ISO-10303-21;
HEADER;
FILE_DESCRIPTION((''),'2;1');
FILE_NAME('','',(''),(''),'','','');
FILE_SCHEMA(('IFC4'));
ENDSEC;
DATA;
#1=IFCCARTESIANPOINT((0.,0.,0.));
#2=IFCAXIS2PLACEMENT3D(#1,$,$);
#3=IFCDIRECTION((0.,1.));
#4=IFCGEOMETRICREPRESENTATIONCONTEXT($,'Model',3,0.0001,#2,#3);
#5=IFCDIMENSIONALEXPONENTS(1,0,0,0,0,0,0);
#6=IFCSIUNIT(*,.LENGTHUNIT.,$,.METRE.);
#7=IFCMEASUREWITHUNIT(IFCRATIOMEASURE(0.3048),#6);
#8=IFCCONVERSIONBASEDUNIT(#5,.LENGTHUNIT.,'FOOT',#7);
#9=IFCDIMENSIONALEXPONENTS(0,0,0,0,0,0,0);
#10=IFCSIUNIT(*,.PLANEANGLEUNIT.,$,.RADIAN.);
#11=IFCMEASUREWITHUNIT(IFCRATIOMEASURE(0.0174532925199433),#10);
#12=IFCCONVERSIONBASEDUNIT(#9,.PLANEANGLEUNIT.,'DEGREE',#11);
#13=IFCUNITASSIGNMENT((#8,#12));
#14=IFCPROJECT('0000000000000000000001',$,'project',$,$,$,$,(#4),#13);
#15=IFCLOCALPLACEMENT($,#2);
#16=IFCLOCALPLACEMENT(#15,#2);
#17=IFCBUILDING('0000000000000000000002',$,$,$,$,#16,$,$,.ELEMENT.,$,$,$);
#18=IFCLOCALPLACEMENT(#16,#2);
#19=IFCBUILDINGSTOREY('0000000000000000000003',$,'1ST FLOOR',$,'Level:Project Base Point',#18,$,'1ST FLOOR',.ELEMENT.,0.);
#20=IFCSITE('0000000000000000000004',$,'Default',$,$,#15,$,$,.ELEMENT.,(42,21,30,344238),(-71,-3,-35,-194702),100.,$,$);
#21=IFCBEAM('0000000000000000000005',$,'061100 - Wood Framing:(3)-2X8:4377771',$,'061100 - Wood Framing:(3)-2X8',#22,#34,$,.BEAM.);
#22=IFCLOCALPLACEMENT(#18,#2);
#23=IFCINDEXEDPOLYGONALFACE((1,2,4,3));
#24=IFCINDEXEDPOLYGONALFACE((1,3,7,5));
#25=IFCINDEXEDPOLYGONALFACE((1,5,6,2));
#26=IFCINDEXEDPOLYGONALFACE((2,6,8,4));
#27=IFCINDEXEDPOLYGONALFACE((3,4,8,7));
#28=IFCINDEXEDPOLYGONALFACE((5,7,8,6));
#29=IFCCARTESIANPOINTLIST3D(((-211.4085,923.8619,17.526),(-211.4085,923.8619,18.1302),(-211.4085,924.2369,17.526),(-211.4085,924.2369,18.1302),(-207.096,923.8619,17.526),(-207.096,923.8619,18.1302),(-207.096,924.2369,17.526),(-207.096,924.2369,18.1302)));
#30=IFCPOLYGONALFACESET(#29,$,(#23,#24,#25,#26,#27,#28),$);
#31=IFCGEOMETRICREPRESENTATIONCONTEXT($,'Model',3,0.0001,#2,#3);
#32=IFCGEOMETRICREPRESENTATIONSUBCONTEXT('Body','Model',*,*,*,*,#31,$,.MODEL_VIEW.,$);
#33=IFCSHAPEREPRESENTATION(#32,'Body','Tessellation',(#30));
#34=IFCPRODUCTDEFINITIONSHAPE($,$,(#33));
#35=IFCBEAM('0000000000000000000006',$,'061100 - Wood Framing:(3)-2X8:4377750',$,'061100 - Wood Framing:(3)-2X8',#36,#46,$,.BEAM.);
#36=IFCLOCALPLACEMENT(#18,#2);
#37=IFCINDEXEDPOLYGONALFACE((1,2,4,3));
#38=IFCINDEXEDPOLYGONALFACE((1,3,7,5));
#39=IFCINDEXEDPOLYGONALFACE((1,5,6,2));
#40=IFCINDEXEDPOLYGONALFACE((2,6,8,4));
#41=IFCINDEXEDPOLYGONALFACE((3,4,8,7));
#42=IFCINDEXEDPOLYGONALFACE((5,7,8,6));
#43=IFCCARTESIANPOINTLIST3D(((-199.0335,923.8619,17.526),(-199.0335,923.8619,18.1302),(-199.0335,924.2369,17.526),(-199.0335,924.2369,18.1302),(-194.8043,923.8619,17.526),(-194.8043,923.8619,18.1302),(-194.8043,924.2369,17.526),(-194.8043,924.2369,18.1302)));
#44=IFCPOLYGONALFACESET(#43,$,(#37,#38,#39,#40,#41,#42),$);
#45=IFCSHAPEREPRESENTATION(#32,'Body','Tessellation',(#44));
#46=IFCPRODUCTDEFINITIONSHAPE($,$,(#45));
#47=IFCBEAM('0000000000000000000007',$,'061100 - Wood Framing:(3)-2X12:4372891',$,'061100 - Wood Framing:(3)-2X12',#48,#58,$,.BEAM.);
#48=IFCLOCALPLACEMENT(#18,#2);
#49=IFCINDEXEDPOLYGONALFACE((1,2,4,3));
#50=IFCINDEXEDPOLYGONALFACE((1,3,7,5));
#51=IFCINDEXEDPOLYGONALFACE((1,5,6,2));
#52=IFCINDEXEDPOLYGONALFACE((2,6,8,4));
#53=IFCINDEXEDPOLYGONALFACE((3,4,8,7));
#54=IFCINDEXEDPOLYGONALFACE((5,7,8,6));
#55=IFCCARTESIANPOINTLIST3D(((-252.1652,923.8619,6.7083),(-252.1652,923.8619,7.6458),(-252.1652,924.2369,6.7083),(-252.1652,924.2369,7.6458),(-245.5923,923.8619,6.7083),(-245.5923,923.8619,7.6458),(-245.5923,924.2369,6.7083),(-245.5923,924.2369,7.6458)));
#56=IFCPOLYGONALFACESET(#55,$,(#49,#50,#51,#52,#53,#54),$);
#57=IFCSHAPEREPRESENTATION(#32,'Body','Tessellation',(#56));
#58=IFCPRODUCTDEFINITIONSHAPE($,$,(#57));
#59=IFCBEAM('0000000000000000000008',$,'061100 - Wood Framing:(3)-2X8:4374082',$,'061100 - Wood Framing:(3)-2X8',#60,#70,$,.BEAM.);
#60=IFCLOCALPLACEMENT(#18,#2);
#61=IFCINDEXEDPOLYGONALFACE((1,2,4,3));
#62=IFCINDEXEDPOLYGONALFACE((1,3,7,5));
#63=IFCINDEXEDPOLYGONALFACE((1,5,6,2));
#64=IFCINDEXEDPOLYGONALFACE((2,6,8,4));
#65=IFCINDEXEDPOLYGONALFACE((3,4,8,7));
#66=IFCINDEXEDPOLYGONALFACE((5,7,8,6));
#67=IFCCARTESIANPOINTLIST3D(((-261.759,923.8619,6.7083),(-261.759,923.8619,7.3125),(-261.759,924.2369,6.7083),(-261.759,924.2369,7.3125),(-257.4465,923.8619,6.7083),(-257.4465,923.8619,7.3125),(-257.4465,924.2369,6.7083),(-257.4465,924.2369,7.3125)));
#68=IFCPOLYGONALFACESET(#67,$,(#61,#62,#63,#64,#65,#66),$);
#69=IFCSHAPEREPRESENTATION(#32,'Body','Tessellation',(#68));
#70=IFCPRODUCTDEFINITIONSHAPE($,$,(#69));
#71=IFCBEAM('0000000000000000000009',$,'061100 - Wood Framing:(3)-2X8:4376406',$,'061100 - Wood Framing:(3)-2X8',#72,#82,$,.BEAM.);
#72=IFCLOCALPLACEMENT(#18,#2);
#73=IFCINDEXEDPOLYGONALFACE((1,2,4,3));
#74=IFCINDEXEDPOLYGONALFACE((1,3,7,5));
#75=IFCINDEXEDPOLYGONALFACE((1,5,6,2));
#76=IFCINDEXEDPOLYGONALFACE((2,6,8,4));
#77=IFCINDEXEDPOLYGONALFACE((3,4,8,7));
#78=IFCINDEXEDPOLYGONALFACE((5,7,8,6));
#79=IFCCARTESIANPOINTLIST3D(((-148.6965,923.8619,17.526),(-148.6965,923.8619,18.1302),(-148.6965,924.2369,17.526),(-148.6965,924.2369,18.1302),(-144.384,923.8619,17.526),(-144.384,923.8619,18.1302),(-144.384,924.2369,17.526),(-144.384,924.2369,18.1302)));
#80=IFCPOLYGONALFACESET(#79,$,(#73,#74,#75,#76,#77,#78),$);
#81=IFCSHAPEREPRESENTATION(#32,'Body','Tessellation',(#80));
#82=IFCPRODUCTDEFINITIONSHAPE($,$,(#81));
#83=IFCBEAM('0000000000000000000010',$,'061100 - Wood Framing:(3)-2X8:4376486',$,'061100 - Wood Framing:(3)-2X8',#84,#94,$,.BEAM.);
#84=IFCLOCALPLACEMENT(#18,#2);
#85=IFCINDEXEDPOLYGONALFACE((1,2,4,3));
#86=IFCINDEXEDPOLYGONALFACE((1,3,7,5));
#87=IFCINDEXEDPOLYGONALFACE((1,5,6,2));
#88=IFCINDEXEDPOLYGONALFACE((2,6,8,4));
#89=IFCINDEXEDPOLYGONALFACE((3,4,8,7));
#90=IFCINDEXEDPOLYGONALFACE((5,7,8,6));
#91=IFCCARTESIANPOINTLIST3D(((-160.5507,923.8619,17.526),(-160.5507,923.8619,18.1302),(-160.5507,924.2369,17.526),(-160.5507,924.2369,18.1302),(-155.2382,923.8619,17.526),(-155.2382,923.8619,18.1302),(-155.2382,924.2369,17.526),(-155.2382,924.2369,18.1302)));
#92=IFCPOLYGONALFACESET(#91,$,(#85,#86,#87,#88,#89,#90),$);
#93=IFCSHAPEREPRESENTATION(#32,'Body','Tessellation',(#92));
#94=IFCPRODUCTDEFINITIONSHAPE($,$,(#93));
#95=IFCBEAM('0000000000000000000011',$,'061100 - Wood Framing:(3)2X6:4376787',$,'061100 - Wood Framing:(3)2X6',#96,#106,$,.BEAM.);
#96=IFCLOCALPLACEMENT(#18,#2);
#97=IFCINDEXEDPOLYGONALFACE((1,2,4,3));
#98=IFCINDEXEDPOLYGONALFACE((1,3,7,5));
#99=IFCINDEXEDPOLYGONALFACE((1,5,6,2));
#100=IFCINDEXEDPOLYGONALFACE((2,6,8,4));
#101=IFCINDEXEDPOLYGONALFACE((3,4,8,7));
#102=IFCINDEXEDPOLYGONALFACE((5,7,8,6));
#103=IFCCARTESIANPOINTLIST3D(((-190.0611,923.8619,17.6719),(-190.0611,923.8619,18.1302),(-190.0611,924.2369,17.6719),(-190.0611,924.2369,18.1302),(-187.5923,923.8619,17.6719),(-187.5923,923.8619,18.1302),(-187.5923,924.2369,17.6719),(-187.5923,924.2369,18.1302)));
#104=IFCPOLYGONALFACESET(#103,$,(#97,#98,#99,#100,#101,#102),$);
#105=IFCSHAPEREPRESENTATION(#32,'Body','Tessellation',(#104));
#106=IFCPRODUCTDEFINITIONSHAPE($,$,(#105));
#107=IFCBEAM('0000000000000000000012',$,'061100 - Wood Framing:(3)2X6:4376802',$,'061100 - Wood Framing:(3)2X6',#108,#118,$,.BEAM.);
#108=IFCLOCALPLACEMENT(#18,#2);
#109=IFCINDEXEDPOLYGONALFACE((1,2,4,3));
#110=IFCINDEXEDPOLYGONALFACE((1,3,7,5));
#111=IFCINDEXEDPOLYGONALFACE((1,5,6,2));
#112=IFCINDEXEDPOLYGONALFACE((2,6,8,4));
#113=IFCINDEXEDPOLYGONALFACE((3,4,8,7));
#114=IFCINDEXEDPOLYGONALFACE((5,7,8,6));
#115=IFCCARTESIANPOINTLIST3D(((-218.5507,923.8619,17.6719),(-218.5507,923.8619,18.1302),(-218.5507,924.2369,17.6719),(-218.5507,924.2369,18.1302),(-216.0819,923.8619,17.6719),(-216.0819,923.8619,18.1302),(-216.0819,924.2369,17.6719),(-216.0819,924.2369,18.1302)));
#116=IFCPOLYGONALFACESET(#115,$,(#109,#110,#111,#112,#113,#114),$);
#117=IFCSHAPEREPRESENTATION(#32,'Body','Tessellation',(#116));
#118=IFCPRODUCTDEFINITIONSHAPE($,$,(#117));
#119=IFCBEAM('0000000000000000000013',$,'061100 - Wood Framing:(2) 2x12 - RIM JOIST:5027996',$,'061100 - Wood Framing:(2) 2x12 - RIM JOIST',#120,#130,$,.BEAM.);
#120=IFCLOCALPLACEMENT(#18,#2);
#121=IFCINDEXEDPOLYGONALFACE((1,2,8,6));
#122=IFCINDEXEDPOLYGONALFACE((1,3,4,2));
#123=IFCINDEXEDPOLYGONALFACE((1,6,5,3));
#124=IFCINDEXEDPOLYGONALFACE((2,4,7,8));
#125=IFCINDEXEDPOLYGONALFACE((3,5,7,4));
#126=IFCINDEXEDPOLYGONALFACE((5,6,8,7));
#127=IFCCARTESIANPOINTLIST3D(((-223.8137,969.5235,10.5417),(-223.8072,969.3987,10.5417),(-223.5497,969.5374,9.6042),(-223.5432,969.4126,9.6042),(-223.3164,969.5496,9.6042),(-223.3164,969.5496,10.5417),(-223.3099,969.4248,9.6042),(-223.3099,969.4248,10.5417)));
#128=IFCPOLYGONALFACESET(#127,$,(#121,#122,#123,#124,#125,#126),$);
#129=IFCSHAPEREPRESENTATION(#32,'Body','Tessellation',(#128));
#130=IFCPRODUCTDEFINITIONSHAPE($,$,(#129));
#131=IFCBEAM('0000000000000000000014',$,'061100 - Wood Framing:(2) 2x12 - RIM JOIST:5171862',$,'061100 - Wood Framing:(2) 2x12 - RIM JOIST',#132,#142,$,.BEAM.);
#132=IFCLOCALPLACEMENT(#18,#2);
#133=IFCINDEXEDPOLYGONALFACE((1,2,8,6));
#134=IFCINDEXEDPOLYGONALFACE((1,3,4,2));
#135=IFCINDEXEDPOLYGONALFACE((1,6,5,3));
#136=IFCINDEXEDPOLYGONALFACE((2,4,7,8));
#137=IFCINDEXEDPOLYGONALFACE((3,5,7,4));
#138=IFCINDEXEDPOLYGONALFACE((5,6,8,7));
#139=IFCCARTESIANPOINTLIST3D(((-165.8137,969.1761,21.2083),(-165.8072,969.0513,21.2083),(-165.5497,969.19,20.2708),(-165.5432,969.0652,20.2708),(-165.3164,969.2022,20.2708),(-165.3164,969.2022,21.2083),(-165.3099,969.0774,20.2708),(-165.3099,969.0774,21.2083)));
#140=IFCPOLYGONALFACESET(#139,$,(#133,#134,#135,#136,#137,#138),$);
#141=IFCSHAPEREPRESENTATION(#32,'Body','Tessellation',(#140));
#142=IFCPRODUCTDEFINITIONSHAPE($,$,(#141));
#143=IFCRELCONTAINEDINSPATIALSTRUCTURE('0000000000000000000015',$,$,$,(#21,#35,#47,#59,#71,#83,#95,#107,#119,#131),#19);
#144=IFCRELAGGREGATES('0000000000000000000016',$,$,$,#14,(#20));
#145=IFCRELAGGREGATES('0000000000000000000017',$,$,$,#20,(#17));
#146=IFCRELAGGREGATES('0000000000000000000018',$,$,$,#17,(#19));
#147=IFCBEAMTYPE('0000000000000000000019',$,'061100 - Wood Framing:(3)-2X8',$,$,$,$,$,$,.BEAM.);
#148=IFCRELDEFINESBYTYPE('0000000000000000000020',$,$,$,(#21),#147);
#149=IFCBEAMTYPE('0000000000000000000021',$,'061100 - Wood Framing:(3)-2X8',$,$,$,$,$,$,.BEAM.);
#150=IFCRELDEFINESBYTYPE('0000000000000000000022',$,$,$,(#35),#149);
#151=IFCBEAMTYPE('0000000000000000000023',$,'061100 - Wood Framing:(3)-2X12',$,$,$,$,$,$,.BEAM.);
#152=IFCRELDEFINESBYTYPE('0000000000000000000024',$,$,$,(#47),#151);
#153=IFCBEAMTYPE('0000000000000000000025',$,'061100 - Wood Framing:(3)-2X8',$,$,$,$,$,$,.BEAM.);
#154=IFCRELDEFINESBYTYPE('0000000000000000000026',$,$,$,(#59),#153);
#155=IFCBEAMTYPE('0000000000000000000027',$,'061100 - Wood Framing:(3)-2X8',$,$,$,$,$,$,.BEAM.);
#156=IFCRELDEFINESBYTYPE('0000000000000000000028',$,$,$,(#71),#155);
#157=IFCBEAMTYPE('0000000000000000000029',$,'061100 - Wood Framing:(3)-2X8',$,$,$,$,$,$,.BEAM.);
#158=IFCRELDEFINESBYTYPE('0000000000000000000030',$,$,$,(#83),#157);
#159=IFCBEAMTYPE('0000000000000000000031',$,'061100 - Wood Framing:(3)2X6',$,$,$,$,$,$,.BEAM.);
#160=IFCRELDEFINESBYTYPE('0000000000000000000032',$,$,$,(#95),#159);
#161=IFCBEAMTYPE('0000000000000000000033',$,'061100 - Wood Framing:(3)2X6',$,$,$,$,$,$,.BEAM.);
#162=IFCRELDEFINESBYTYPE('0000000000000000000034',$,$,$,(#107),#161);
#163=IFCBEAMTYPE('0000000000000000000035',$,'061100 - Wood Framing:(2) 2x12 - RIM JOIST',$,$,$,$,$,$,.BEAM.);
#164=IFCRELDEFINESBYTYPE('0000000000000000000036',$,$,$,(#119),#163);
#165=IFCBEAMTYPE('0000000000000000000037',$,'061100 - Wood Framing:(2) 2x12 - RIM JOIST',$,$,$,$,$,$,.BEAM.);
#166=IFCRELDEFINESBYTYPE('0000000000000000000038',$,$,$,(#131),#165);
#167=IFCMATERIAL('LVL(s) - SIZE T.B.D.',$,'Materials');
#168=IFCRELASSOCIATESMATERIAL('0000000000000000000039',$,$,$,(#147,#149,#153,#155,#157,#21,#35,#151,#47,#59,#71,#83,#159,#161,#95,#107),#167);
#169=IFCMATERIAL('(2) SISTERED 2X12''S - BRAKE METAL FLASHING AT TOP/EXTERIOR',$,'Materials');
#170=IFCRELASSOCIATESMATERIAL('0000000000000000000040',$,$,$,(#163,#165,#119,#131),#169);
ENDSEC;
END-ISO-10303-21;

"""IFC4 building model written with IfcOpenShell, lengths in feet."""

from ifc_helpers import new_model, entity, si_unit, converted_unit, direction, frame, frame_2d, origin, place, context, subcontext, project, spatial, rectangle, extrude, clip, halfspace, source, transform, mapped, material, material_profile, profile_set, profile_usage, type_object, type_shapes, element, save


model = new_model("IFC4")

# Units and contexts
model_context_1 = context("Model", 3, precision=0.0001, world=origin(), true_north=direction((0.0, 1.0)))
model_context_2 = context("Model", 3, precision=0.0001, world=origin(), true_north=direction((0.0, 1.0)))
body_context = subcontext(model_context_2, "Body", "Model", "MODEL_VIEW")
ifc_project = project(units=[converted_unit("LENGTHUNIT", "FOOT", entity("IfcRatioMeasure", 0.3048), si_unit("LENGTHUNIT", "METRE"), dimensions=[1, 0, 0, 0, 0, 0, 0]), converted_unit("PLANEANGLEUNIT", "DEGREE", entity("IfcRatioMeasure", 0.0174532925199433), si_unit("PLANEANGLEUNIT", "RADIAN"), dimensions=[0, 0, 0, 0, 0, 0, 0])], contexts=[model_context_1])

# Site, building, storey
site_placement = place(None, origin())
site = spatial("IfcSite", under=ifc_project, at=site_placement, Name="Default", CompositionType="ELEMENT", RefLatitude=(42, 21, 30, 344238), RefLongitude=(-71, -3, -35, -194702), RefElevation=100.0)
building_placement = place(site_placement, origin())
building = spatial("IfcBuilding", under=site, at=building_placement, CompositionType="ELEMENT")
storey_placement = place(building_placement, origin())
storey = spatial("IfcBuildingStorey", under=building, at=storey_placement, Name="1ST FLOOR", ObjectType="Level:Project Base Point", LongName="1ST FLOOR", CompositionType="ELEMENT", Elevation=0.0)

# Beams
ifc_material_1 = material(Name="LVL(s) - SIZE T.B.D.", Category="Materials")
ifc_material_profile_1 = material_profile(ifc_material_1, rectangle(XDim=0.6042, YDim=0.375, at=frame_2d((0.0, 0.0), x_axis=(1.0, 0.0))), Name="(3)-2X8")
ifc_profile_set_1 = profile_set([ifc_material_profile_1], Name="(3)-2X8")
ifc_profile_usage_1 = profile_usage(ifc_profile_set_1, cardinal=8)
beam_type_1 = type_object("IfcBeamType", Name="061100 - Wood Framing:(3)-2X8", PredefinedType="BEAM", material=ifc_profile_set_1)
shared_shape_1 = source(origin(), body_context, "Body", "SweptSolid", [
    extrude(rectangle(XDim=0.6042, YDim=0.375, at=frame_2d((0.0, 0.0), x_axis=(1.0, 0.0))), frame((-2.1777, 0.0, 0.0), z_axis=(1.0, 0.0, 0.0), x_axis=(0.0, 0.0, -1.0)), (0.0, 0.0, 1.0), 4.3125),
])
type_shapes(beam_type_1, [shared_shape_1])
beam_1_placement = place(storey_placement, frame((-209.2308, 924.0494, 17.8281)))
element("IfcBeam", 1, at=beam_1_placement, inside=storey, type_object=beam_type_1, material=ifc_profile_usage_1, Name="061100 - Wood Framing:(3)-2X8:4377771", ObjectType="061100 - Wood Framing:(3)-2X8", PredefinedType="BEAM", context=body_context, shape_type="MappedRepresentation", body=[
    mapped(shared_shape_1, transform((0.0, 0.0, 0.0), scale=1.0)),
])
ifc_profile_usage_2 = profile_usage(ifc_profile_set_1, cardinal=8)
beam_type_2 = type_object("IfcBeamType", Name="061100 - Wood Framing:(3)-2X8", PredefinedType="BEAM", material=ifc_profile_set_1)
shared_shape_2 = source(origin(), body_context, "Body", "SweptSolid", [
    extrude(rectangle(XDim=0.6042, YDim=0.375, at=frame_2d((0.0, 0.0), x_axis=(1.0, 0.0))), frame((-2.136, 0.0, 0.0), z_axis=(1.0, 0.0, 0.0), x_axis=(0.0, 0.0, -1.0)), (0.0, 0.0, 1.0), 4.2292),
])
type_shapes(beam_type_2, [shared_shape_2])
beam_2_placement = place(storey_placement, frame((-196.8975, 924.0494, 17.8281)))
element("IfcBeam", 2, at=beam_2_placement, inside=storey, type_object=beam_type_2, material=ifc_profile_usage_2, Name="061100 - Wood Framing:(3)-2X8:4377750", ObjectType="061100 - Wood Framing:(3)-2X8", PredefinedType="BEAM", context=body_context, shape_type="MappedRepresentation", body=[
    mapped(shared_shape_2, transform((0.0, 0.0, 0.0), scale=1.0)),
])
ifc_material_profile_2 = material_profile(ifc_material_1, rectangle(XDim=0.9375, YDim=0.375, at=frame_2d((0.0, 0.0), x_axis=(1.0, 0.0))), Name="(3)-2X12")
ifc_profile_set_2 = profile_set([ifc_material_profile_2], Name="(3)-2X12")
ifc_profile_usage_3 = profile_usage(ifc_profile_set_2, cardinal=8)
beam_type_3 = type_object("IfcBeamType", Name="061100 - Wood Framing:(3)-2X12", PredefinedType="BEAM", material=ifc_profile_set_2)
shared_shape_3 = source(origin(), body_context, "Body", "SweptSolid", [
    extrude(rectangle(XDim=0.9375, YDim=0.375, at=frame_2d((0.0, 0.0), x_axis=(1.0, 0.0))), frame((-3.2765, 0.0, 0.0), z_axis=(1.0, 0.0, 0.0), x_axis=(0.0, 0.0, -1.0)), (0.0, 0.0, 1.0), 6.5729),
])
type_shapes(beam_type_3, [shared_shape_3])
beam_3_placement = place(storey_placement, frame((-248.8888, 924.0494, 7.1771)))
element("IfcBeam", 3, at=beam_3_placement, inside=storey, type_object=beam_type_3, material=ifc_profile_usage_3, Name="061100 - Wood Framing:(3)-2X12:4372891", ObjectType="061100 - Wood Framing:(3)-2X12", PredefinedType="BEAM", context=body_context, shape_type="MappedRepresentation", body=[
    mapped(shared_shape_3, transform((0.0, 0.0, 0.0), scale=1.0)),
])
ifc_profile_usage_4 = profile_usage(ifc_profile_set_1, cardinal=8)
beam_type_4 = type_object("IfcBeamType", Name="061100 - Wood Framing:(3)-2X8", PredefinedType="BEAM", material=ifc_profile_set_1)
shared_shape_4 = source(origin(), body_context, "Body", "SweptSolid", [
    extrude(rectangle(XDim=0.6042, YDim=0.375, at=frame_2d((0.0, 0.0), x_axis=(1.0, 0.0))), frame((-2.1594, 0.0, 0.0), z_axis=(1.0, 0.0, 0.0), x_axis=(0.0, 0.0, -1.0)), (0.0, 0.0, 1.0), 4.3125),
])
type_shapes(beam_type_4, [shared_shape_4])
beam_4_placement = place(storey_placement, frame((-259.5996, 924.0494, 7.0104)))
element("IfcBeam", 4, at=beam_4_placement, inside=storey, type_object=beam_type_4, material=ifc_profile_usage_4, Name="061100 - Wood Framing:(3)-2X8:4374082", ObjectType="061100 - Wood Framing:(3)-2X8", PredefinedType="BEAM", context=body_context, shape_type="MappedRepresentation", body=[
    mapped(shared_shape_4, transform((0.0, 0.0, 0.0), scale=1.0)),
])
ifc_profile_usage_5 = profile_usage(ifc_profile_set_1, cardinal=8)
beam_type_5 = type_object("IfcBeamType", Name="061100 - Wood Framing:(3)-2X8", PredefinedType="BEAM", material=ifc_profile_set_1)
shared_shape_5 = source(origin(), body_context, "Body", "SweptSolid", [
    extrude(rectangle(XDim=0.6042, YDim=0.375, at=frame_2d((0.0, 0.0), x_axis=(1.0, 0.0))), frame((-2.1777, 0.0, 0.0), z_axis=(1.0, 0.0, 0.0), x_axis=(0.0, 0.0, -1.0)), (0.0, 0.0, 1.0), 4.3125),
])
type_shapes(beam_type_5, [shared_shape_5])
beam_5_placement = place(storey_placement, frame((-146.5188, 924.0494, 17.8281)))
element("IfcBeam", 5, at=beam_5_placement, inside=storey, type_object=beam_type_5, material=ifc_profile_usage_5, Name="061100 - Wood Framing:(3)-2X8:4376406", ObjectType="061100 - Wood Framing:(3)-2X8", PredefinedType="BEAM", context=body_context, shape_type="MappedRepresentation", body=[
    mapped(shared_shape_5, transform((0.0, 0.0, 0.0), scale=1.0)),
])
ifc_profile_usage_6 = profile_usage(ifc_profile_set_1, cardinal=8)
beam_type_6 = type_object("IfcBeamType", Name="061100 - Wood Framing:(3)-2X8", PredefinedType="BEAM", material=ifc_profile_set_1)
shared_shape_6 = source(origin(), body_context, "Body", "SweptSolid", [
    extrude(rectangle(XDim=0.6042, YDim=0.375, at=frame_2d((0.0, 0.0), x_axis=(1.0, 0.0))), frame((-2.6596, 0.0, 0.0), z_axis=(1.0, 0.0, 0.0), x_axis=(0.0, 0.0, -1.0)), (0.0, 0.0, 1.0), 5.3125),
])
type_shapes(beam_type_6, [shared_shape_6])
beam_6_placement = place(storey_placement, frame((-157.891, 924.0494, 17.8281)))
element("IfcBeam", 6, at=beam_6_placement, inside=storey, type_object=beam_type_6, material=ifc_profile_usage_6, Name="061100 - Wood Framing:(3)-2X8:4376486", ObjectType="061100 - Wood Framing:(3)-2X8", PredefinedType="BEAM", context=body_context, shape_type="MappedRepresentation", body=[
    mapped(shared_shape_6, transform((0.0, 0.0, 0.0), scale=1.0)),
])
ifc_material_profile_3 = material_profile(ifc_material_1, rectangle(XDim=0.4583, YDim=0.375, at=frame_2d((0.0, 0.0), x_axis=(1.0, 0.0))), Name="(3)2X6")
ifc_profile_set_3 = profile_set([ifc_material_profile_3], Name="(3)2X6")
ifc_profile_usage_7 = profile_usage(ifc_profile_set_3, cardinal=8)
beam_type_7 = type_object("IfcBeamType", Name="061100 - Wood Framing:(3)2X6", PredefinedType="BEAM", material=ifc_profile_set_3)
shared_shape_7 = source(origin(), body_context, "Body", "SweptSolid", [
    extrude(rectangle(XDim=0.4583, YDim=0.375, at=frame_2d((0.0, 0.0), x_axis=(1.0, 0.0))), frame((-1.2286, 0.0, 0.0), z_axis=(1.0, 0.0, 0.0), x_axis=(0.0, 0.0, -1.0)), (0.0, 0.0, 1.0), 2.4687),
])
type_shapes(beam_type_7, [shared_shape_7])
beam_7_placement = place(storey_placement, frame((-188.8325, 924.0494, 17.901)))
element("IfcBeam", 7, at=beam_7_placement, inside=storey, type_object=beam_type_7, material=ifc_profile_usage_7, Name="061100 - Wood Framing:(3)2X6:4376787", ObjectType="061100 - Wood Framing:(3)2X6", PredefinedType="BEAM", context=body_context, shape_type="MappedRepresentation", body=[
    mapped(shared_shape_7, transform((0.0, 0.0, 0.0), scale=1.0)),
])
ifc_profile_usage_8 = profile_usage(ifc_profile_set_3, cardinal=8)
beam_type_8 = type_object("IfcBeamType", Name="061100 - Wood Framing:(3)2X6", PredefinedType="BEAM", material=ifc_profile_set_3)
shared_shape_8 = source(origin(), body_context, "Body", "SweptSolid", [
    extrude(rectangle(XDim=0.4583, YDim=0.375, at=frame_2d((0.0, 0.0), x_axis=(1.0, 0.0))), frame((-1.2212, 0.0, 0.0), z_axis=(1.0, 0.0, 0.0), x_axis=(0.0, 0.0, -1.0)), (0.0, 0.0, 1.0), 2.4687),
])
type_shapes(beam_type_8, [shared_shape_8])
beam_8_placement = place(storey_placement, frame((-217.3294, 924.0494, 17.901)))
element("IfcBeam", 8, at=beam_8_placement, inside=storey, type_object=beam_type_8, material=ifc_profile_usage_8, Name="061100 - Wood Framing:(3)2X6:4376802", ObjectType="061100 - Wood Framing:(3)2X6", PredefinedType="BEAM", context=body_context, shape_type="MappedRepresentation", body=[
    mapped(shared_shape_8, transform((0.0, 0.0, 0.0), scale=1.0)),
])
ifc_material_2 = material(Name="(2) SISTERED 2X12'S - BRAKE METAL FLASHING AT TOP/EXTERIOR", Category="Materials")
ifc_material_profile_4 = material_profile(ifc_material_2, rectangle(XDim=0.9375, YDim=0.125, at=frame_2d((0.0, 0.0), x_axis=(1.0, 0.0))), Name="(2) 2x12 - RIM JOIST")
ifc_profile_set_4 = profile_set([ifc_material_profile_4], Name="(2) 2x12 - RIM JOIST")
ifc_profile_usage_9 = profile_usage(ifc_profile_set_4, cardinal=2)
beam_type_9 = type_object("IfcBeamType", Name="061100 - Wood Framing:(2) 2x12 - RIM JOIST", PredefinedType="BEAM", material=ifc_profile_set_4)
shared_shape_9 = source(origin(), body_context, "Body", "Clipping", [
    clip(extrude(rectangle(XDim=0.9375, YDim=0.125, at=frame_2d((0.0, 0.0), x_axis=(1.0, 0.0))), frame((-223.8105, 969.4611, 10.0729), z_axis=(0.99863, 0.052336, 0.0), x_axis=(0.0, 0.0, 1.0)), (0.0, 0.0, 1.0), 0.498), halfspace(frame((-223.7277, 966.3933, 10.818), z_axis=(-0.961136, -0.050371, -0.27144), x_axis=(0.271068, 0.014206, -0.962455)), False)),
])
type_shapes(beam_type_9, [shared_shape_9])
beam_9_placement = place(storey_placement, origin())
element("IfcBeam", 9, at=beam_9_placement, inside=storey, type_object=beam_type_9, material=ifc_profile_usage_9, Name="061100 - Wood Framing:(2) 2x12 - RIM JOIST:5027996", ObjectType="061100 - Wood Framing:(2) 2x12 - RIM JOIST", PredefinedType="BEAM", context=body_context, shape_type="MappedRepresentation", body=[
    mapped(shared_shape_9, transform((0.0, 0.0, 0.0), scale=1.0)),
])
ifc_profile_usage_10 = profile_usage(ifc_profile_set_4, cardinal=2)
beam_type_10 = type_object("IfcBeamType", Name="061100 - Wood Framing:(2) 2x12 - RIM JOIST", PredefinedType="BEAM", material=ifc_profile_set_4)
shared_shape_10 = source(origin(), body_context, "Body", "Clipping", [
    clip(extrude(rectangle(XDim=0.9375, YDim=0.125, at=frame_2d((0.0, 0.0), x_axis=(1.0, 0.0))), frame((-165.8105, 969.1137, 20.7396), z_axis=(0.99863, 0.052336, 0.0), x_axis=(0.0, 0.0, 1.0)), (0.0, 0.0, 1.0), 0.498), halfspace(frame((-165.2632, 966.0702, 19.8354), z_axis=(-0.961136, -0.050371, -0.27144), x_axis=(0.271068, 0.014206, -0.962455)), False)),
])
type_shapes(beam_type_10, [shared_shape_10])
beam_10_placement = place(storey_placement, origin())
element("IfcBeam", 10, at=beam_10_placement, inside=storey, type_object=beam_type_10, material=ifc_profile_usage_10, Name="061100 - Wood Framing:(2) 2x12 - RIM JOIST:5171862", ObjectType="061100 - Wood Framing:(2) 2x12 - RIM JOIST", PredefinedType="BEAM", context=body_context, shape_type="MappedRepresentation", body=[
    mapped(shared_shape_10, transform((0.0, 0.0, 0.0), scale=1.0)),
])

save(model, "model.ifc")
